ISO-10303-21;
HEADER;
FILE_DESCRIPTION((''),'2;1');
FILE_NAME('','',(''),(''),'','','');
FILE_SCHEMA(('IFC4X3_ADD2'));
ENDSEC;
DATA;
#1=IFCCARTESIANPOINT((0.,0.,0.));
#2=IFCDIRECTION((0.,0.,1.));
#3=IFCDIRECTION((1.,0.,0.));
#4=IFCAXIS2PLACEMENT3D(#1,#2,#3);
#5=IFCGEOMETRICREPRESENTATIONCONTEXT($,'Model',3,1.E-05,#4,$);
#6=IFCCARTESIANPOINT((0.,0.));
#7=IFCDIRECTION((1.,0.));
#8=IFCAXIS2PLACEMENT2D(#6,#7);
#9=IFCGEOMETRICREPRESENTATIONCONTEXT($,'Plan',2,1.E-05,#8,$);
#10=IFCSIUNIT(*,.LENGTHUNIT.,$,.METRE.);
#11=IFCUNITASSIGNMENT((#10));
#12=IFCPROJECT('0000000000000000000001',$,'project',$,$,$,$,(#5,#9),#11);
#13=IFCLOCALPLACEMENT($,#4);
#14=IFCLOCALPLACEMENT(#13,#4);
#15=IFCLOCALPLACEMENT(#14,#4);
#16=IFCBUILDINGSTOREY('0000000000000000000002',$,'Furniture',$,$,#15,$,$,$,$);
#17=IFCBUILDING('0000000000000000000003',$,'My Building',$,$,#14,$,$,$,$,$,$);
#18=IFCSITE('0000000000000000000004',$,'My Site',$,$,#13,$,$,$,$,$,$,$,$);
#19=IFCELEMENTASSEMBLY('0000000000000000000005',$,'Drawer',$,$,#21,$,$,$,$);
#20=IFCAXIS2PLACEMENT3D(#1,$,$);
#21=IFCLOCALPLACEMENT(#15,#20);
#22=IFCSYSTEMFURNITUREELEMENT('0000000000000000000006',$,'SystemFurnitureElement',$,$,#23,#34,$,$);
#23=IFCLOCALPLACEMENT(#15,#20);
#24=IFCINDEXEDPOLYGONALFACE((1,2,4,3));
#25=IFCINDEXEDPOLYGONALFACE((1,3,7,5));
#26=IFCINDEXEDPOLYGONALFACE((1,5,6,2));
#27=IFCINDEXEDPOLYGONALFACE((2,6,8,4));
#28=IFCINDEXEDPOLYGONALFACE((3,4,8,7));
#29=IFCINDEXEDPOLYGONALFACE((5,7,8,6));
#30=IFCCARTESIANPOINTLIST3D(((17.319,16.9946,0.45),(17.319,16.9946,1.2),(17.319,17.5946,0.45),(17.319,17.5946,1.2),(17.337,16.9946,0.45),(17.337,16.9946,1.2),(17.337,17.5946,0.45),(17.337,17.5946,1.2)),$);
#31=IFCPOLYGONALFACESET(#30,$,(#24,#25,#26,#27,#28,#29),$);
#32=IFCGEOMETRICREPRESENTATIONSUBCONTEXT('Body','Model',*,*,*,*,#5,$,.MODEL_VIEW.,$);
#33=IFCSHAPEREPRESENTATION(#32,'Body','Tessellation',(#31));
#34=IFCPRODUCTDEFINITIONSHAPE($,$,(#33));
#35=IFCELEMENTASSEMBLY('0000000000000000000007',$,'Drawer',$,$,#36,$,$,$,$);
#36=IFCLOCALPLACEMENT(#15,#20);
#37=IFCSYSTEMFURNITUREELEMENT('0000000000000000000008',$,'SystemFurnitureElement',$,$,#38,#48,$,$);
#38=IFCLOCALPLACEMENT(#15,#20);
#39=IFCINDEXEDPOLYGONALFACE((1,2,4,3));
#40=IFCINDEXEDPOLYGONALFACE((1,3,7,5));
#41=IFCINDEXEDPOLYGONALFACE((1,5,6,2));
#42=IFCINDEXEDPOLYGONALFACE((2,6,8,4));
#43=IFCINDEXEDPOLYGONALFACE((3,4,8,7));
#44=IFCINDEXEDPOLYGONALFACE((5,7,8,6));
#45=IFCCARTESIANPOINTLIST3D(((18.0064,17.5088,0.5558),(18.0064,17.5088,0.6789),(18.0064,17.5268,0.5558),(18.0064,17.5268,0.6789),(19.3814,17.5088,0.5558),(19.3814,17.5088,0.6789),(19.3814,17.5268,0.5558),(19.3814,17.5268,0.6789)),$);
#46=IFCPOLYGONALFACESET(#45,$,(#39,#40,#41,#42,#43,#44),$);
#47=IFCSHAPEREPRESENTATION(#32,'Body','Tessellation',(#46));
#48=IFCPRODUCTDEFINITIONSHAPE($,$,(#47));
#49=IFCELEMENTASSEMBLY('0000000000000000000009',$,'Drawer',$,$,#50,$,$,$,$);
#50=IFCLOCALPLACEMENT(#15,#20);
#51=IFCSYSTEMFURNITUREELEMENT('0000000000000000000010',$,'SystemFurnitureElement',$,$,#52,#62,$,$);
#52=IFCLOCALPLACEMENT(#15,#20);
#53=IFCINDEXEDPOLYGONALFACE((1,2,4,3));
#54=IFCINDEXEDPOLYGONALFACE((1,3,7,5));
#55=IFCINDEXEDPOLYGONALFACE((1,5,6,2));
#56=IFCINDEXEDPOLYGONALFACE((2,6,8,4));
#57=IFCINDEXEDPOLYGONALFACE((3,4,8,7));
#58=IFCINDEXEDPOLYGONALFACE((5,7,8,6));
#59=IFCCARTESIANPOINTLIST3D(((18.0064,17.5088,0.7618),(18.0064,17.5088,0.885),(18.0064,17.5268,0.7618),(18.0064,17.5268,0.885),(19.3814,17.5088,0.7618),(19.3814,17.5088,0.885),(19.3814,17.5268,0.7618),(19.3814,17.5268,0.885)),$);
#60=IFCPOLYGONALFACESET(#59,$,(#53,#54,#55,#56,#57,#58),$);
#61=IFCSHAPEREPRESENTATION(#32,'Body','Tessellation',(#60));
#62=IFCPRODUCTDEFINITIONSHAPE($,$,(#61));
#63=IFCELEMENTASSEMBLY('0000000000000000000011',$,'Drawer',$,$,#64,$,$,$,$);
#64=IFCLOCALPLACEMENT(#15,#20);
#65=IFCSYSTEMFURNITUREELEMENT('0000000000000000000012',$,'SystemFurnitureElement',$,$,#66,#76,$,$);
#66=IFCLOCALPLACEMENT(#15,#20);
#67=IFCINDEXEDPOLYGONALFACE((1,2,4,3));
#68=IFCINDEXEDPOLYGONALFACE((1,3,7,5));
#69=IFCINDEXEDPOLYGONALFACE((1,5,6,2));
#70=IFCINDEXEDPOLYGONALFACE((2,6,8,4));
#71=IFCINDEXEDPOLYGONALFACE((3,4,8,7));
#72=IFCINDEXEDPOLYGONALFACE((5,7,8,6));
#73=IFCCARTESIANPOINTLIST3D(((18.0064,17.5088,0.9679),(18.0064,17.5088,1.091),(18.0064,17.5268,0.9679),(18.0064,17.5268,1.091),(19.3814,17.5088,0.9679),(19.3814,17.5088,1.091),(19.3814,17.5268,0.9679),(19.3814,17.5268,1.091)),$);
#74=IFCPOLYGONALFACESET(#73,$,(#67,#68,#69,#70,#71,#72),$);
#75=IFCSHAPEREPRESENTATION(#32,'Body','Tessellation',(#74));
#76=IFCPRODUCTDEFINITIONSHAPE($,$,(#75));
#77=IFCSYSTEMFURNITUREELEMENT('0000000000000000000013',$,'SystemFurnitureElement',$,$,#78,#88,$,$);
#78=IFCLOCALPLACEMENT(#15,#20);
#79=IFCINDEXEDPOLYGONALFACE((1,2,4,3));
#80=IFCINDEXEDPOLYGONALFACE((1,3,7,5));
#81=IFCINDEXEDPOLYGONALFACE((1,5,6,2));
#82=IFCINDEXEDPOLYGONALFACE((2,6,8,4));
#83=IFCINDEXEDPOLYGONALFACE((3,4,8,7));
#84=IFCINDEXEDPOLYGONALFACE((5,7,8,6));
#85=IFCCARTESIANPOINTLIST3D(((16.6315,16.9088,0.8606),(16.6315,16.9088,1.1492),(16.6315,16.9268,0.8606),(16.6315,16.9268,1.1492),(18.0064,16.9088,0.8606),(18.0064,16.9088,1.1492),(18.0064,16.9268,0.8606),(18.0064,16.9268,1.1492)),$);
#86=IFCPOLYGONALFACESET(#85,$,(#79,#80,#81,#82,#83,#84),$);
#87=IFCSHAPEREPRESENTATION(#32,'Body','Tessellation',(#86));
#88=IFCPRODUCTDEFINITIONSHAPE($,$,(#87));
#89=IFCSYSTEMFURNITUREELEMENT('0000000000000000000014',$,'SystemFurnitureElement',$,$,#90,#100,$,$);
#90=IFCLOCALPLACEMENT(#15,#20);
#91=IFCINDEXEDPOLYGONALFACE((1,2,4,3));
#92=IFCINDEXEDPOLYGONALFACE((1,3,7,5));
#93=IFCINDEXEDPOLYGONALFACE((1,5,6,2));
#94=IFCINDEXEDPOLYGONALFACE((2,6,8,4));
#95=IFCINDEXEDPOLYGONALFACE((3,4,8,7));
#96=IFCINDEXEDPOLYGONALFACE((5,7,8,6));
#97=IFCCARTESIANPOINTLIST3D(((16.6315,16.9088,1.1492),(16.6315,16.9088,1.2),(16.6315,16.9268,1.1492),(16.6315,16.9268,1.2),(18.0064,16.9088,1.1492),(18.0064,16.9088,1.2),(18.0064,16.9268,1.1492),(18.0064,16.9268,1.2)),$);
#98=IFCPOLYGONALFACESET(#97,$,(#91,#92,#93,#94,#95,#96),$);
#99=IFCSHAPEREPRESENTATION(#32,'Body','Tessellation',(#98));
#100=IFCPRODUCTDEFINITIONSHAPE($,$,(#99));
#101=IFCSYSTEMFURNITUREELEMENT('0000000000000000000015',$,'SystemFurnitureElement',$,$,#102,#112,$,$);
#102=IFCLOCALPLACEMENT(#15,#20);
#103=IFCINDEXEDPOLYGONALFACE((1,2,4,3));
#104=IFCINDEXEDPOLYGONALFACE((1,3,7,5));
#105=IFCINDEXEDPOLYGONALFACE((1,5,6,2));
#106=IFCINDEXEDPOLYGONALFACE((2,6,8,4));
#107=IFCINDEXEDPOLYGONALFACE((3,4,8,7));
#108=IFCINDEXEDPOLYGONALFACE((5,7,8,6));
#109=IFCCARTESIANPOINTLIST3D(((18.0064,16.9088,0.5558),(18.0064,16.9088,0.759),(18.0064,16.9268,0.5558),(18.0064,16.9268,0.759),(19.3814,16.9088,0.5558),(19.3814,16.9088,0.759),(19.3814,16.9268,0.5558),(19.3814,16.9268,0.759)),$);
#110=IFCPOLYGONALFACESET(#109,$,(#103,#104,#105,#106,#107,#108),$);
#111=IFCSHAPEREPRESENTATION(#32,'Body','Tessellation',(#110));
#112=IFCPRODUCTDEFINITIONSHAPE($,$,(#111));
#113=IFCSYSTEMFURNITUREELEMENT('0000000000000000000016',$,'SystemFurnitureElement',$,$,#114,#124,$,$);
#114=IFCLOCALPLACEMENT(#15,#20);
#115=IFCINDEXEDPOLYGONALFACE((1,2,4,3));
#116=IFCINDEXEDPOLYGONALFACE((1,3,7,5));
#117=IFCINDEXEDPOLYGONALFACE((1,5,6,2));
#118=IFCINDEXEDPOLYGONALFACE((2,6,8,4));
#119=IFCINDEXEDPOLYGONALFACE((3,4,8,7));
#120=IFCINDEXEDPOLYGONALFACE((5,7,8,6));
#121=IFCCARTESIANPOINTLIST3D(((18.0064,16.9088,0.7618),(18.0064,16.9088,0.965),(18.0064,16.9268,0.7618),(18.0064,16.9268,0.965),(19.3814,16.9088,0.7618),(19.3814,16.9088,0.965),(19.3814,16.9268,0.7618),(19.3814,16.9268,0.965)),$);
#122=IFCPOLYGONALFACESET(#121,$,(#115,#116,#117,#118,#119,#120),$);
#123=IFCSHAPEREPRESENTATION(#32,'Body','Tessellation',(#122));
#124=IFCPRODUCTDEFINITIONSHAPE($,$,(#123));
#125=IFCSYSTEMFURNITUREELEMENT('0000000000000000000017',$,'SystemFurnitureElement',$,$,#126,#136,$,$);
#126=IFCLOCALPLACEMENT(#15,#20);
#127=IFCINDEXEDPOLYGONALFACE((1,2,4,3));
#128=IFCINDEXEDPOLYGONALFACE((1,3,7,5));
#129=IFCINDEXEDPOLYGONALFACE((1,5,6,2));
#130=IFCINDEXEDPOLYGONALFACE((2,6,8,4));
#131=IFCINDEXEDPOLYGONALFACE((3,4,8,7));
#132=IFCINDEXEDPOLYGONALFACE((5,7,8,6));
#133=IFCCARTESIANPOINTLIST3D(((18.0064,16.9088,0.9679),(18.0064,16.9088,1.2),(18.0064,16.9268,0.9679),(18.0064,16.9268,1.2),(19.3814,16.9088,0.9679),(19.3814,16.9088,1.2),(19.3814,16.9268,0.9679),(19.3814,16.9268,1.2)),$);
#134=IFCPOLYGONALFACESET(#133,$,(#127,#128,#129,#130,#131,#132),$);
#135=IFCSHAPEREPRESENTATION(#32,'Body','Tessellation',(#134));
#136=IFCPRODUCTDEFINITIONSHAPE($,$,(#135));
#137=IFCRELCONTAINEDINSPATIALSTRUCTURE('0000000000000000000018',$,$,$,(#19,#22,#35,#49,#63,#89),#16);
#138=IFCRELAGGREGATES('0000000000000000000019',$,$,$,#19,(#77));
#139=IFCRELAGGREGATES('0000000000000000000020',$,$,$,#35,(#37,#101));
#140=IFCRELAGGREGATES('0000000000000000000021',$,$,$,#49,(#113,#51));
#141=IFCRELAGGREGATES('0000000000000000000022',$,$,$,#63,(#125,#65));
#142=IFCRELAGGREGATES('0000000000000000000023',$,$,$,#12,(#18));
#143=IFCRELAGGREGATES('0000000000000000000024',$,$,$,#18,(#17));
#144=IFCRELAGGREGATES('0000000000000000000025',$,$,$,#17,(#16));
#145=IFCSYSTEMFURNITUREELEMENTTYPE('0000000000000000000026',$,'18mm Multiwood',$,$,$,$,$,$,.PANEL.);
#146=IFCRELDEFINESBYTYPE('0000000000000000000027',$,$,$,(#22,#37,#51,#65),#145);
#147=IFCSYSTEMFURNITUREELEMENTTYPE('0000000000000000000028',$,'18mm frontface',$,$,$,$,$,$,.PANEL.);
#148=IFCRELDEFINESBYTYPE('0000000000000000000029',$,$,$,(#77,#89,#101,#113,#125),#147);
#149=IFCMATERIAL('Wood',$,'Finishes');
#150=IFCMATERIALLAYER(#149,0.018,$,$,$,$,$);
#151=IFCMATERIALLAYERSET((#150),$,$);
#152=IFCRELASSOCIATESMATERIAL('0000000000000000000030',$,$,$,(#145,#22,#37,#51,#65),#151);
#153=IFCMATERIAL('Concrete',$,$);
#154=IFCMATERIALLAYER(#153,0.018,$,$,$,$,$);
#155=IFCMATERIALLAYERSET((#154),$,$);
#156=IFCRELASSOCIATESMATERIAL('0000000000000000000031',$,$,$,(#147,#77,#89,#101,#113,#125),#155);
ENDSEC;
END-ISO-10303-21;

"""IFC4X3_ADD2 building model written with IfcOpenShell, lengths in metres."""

from ifc_helpers import new_model, si_unit, frame, origin_with_axes, origin_2d_with_axis, place, context, subcontext, project, spatial, line, indexed_curve, outline, extrude, material, layer, layer_set, layer_usage, type_object, element, aggregate, save


model = new_model("IFC4X3_ADD2")

# Units and contexts
model_context = context("Model", 3, precision=1e-05, world=origin_with_axes())
plan_context = context("Plan", 2, precision=1e-05, world=origin_2d_with_axis())
body_context = subcontext(model_context, "Body", "Model", "MODEL_VIEW")
ifc_project = project(units=[si_unit("LENGTHUNIT", "METRE")], contexts=[model_context, plan_context])

# Site, building, storey
site_placement = place(None, origin_with_axes())
site = spatial("IfcSite", under=ifc_project, at=site_placement, Name="My Site")
building_placement = place(site_placement, origin_with_axes())
building = spatial("IfcBuilding", under=site, at=building_placement, Name="My Building")
storey_placement = place(building_placement, origin_with_axes())
storey = spatial("IfcBuildingStorey", under=building, at=storey_placement, Name="Furniture")

# Shared definitions
ifc_material_1 = material(Name="Wood", Category="Finishes")
ifc_layer_1 = layer(ifc_material_1, 0.018)
ifc_layer_set_1 = layer_set([ifc_layer_1])
system_furniture_element_type_1 = type_object("IfcSystemFurnitureElementType", Name="18mm Multiwood", PredefinedType="PANEL", material=ifc_layer_set_1)

# Element assembly
assembly_1_placement = place(storey_placement, frame((16.6315, 16.9088, 0.8606), z_axis=(0.0, 0.0, 1.0), x_axis=(-1.0, 0.0, 0.0)))
assembly_1 = element("IfcElementAssembly", 1, at=assembly_1_placement, inside=storey, Name="Drawer")

# System furniture element
ifc_layer_usage_1 = layer_usage(ifc_layer_set_1, "AXIS2", "POSITIVE", 0.0)
system_furniture_element_1_placement = place(storey_placement, frame((17.337, 16.9946, 0.45), z_axis=(0.0, 0.0, 1.0), x_axis=(0.000001, 1.0, 0.0)))
element("IfcSystemFurnitureElement", 2, at=system_furniture_element_1_placement, inside=storey, type_object=system_furniture_element_type_1, material=ifc_layer_usage_1, Name="SystemFurnitureElement", context=body_context, shape_type="SweptSolid", body=[
    extrude(outline(indexed_curve([(0.0, 0.0), (0.0, 0.018), (0.6, 0.018), (0.6, 0.0)], segments=[line(1, 2, 3, 4, 1)])), origin_with_axes(), (0.0, 0.0, 1.0), 0.75),
])

# Element assemblies, system furniture elements
assembly_2_placement = place(storey_placement, frame((18.0064, 16.9088, 0.5558), z_axis=(0.0, 0.0, 1.0), x_axis=(-1.0, 0.0, 0.0)))
assembly_2 = element("IfcElementAssembly", 3, at=assembly_2_placement, inside=storey, Name="Drawer")
ifc_layer_usage_2 = layer_usage(ifc_layer_set_1, "AXIS2", "POSITIVE", 0.0)
system_furniture_element_2_placement = place(assembly_2_placement, frame((-1.375, -0.618, 0.0), z_axis=(0.0, 0.0, 1.0), x_axis=(1.0, 0.0, 0.0)))
system_furniture_element_2 = element("IfcSystemFurnitureElement", 4, at=system_furniture_element_2_placement, type_object=system_furniture_element_type_1, material=ifc_layer_usage_2, Name="SystemFurnitureElement", context=body_context, shape_type="SweptSolid", body=[
    extrude(outline(indexed_curve([(0.0, 0.0), (0.0, 0.018), (1.375, 0.018), (1.375, 0.0)], segments=[line(1, 2, 3, 4, 1)])), origin_with_axes(), (0.0, 0.0, 1.0), 0.1231),
])
assembly_3_placement = place(storey_placement, frame((18.0064, 16.9088, 0.7618), z_axis=(0.0, 0.0, 1.0), x_axis=(-1.0, 0.0, 0.0)))
assembly_3 = element("IfcElementAssembly", 5, at=assembly_3_placement, inside=storey, Name="Drawer")
ifc_layer_usage_3 = layer_usage(ifc_layer_set_1, "AXIS2", "POSITIVE", 0.0)
system_furniture_element_3_placement = place(assembly_3_placement, frame((-1.375, -0.618, 0.0), z_axis=(0.0, 0.0, 1.0), x_axis=(1.0, 0.0, 0.0)))
system_furniture_element_3 = element("IfcSystemFurnitureElement", 6, at=system_furniture_element_3_placement, type_object=system_furniture_element_type_1, material=ifc_layer_usage_3, Name="SystemFurnitureElement", context=body_context, shape_type="SweptSolid", body=[
    extrude(outline(indexed_curve([(0.0, 0.0), (0.0, 0.018), (1.375, 0.018), (1.375, 0.0)], segments=[line(1, 2, 3, 4, 1)])), origin_with_axes(), (0.0, 0.0, 1.0), 0.1231),
])
assembly_4_placement = place(storey_placement, frame((18.0064, 16.9088, 0.9679), z_axis=(0.0, 0.0, 1.0), x_axis=(-1.0, 0.0, 0.0)))
assembly_4 = element("IfcElementAssembly", 7, at=assembly_4_placement, inside=storey, Name="Drawer")
ifc_layer_usage_4 = layer_usage(ifc_layer_set_1, "AXIS2", "POSITIVE", 0.0)
system_furniture_element_4_placement = place(assembly_4_placement, frame((-1.375, -0.618, 0.0), z_axis=(0.0, 0.0, 1.0), x_axis=(1.0, 0.0, 0.0)))
system_furniture_element_4 = element("IfcSystemFurnitureElement", 8, at=system_furniture_element_4_placement, type_object=system_furniture_element_type_1, material=ifc_layer_usage_4, Name="SystemFurnitureElement", context=body_context, shape_type="SweptSolid", body=[
    extrude(outline(indexed_curve([(0.0, 0.0), (0.0, 0.018), (1.375, 0.018), (1.375, 0.0)], segments=[line(1, 2, 3, 4, 1)])), origin_with_axes(), (0.0, 0.0, 1.0), 0.1231),
])

# System furniture elements
ifc_material_2 = material(Name="Concrete")
ifc_layer_2 = layer(ifc_material_2, 0.018)
ifc_layer_set_2 = layer_set([ifc_layer_2])
ifc_layer_usage_5 = layer_usage(ifc_layer_set_2, "AXIS2", "POSITIVE", 0.0)
system_furniture_element_type_2 = type_object("IfcSystemFurnitureElementType", Name="18mm frontface", PredefinedType="PANEL", material=ifc_layer_set_2)
system_furniture_element_5_placement = place(assembly_1_placement, frame((-1.375, -0.018, 0.0), z_axis=(0.0, 0.0, 1.0), x_axis=(1.0, 0.0, 0.0)))
system_furniture_element_5 = element("IfcSystemFurnitureElement", 9, at=system_furniture_element_5_placement, type_object=system_furniture_element_type_2, material=ifc_layer_usage_5, Name="SystemFurnitureElement", context=body_context, shape_type="SweptSolid", body=[
    extrude(outline(indexed_curve([(0.0, 0.0), (0.0, 0.018), (1.375, 0.018), (1.375, 0.0)], segments=[line(1, 2, 3, 4, 1)])), origin_with_axes(), (0.0, 0.0, 1.0), 0.2886),
])
aggregate(assembly_1, [system_furniture_element_5])
ifc_layer_usage_6 = layer_usage(ifc_layer_set_2, "AXIS2", "POSITIVE", 0.0)
system_furniture_element_6_placement = place(storey_placement, frame((18.0064, 16.9268, 1.1492), z_axis=(0.0, 0.0, 1.0), x_axis=(-1.0, 0.000001, 0.0)))
element("IfcSystemFurnitureElement", 10, at=system_furniture_element_6_placement, inside=storey, type_object=system_furniture_element_type_2, material=ifc_layer_usage_6, Name="SystemFurnitureElement", context=body_context, shape_type="SweptSolid", body=[
    extrude(outline(indexed_curve([(0.0, 0.0), (0.0, 0.018), (1.375, 0.018), (1.375, 0.0)], segments=[line(1, 2, 3, 4, 1)])), origin_with_axes(), (0.0, 0.0, 1.0), 0.0508),
])
ifc_layer_usage_7 = layer_usage(ifc_layer_set_2, "AXIS2", "POSITIVE", 0.0)
system_furniture_element_7_placement = place(assembly_2_placement, frame((-1.375, -0.018, 0.0), z_axis=(0.0, 0.0, 1.0), x_axis=(1.0, 0.0, 0.0)))
system_furniture_element_7 = element("IfcSystemFurnitureElement", 11, at=system_furniture_element_7_placement, type_object=system_furniture_element_type_2, material=ifc_layer_usage_7, Name="SystemFurnitureElement", context=body_context, shape_type="SweptSolid", body=[
    extrude(outline(indexed_curve([(0.0, 0.0), (0.0, 0.018), (1.375, 0.018), (1.375, 0.0)], segments=[line(1, 2, 3, 4, 1)])), origin_with_axes(), (0.0, 0.0, 1.0), 0.2032),
])
aggregate(assembly_2, [system_furniture_element_2, system_furniture_element_7])
ifc_layer_usage_8 = layer_usage(ifc_layer_set_2, "AXIS2", "POSITIVE", 0.0)
system_furniture_element_8_placement = place(assembly_3_placement, frame((-1.375, -0.018, 0.0), z_axis=(0.0, 0.0, 1.0), x_axis=(1.0, 0.0, 0.0)))
system_furniture_element_8 = element("IfcSystemFurnitureElement", 12, at=system_furniture_element_8_placement, type_object=system_furniture_element_type_2, material=ifc_layer_usage_8, Name="SystemFurnitureElement", context=body_context, shape_type="SweptSolid", body=[
    extrude(outline(indexed_curve([(0.0, 0.0), (0.0, 0.018), (1.375, 0.018), (1.375, 0.0)], segments=[line(1, 2, 3, 4, 1)])), origin_with_axes(), (0.0, 0.0, 1.0), 0.2032),
])
aggregate(assembly_3, [system_furniture_element_8, system_furniture_element_3])
ifc_layer_usage_9 = layer_usage(ifc_layer_set_2, "AXIS2", "POSITIVE", 0.0)
system_furniture_element_9_placement = place(assembly_4_placement, frame((-1.375, -0.018, 0.0), z_axis=(0.0, 0.0, 1.0), x_axis=(1.0, 0.0, 0.0)))
system_furniture_element_9 = element("IfcSystemFurnitureElement", 13, at=system_furniture_element_9_placement, type_object=system_furniture_element_type_2, material=ifc_layer_usage_9, Name="SystemFurnitureElement", context=body_context, shape_type="SweptSolid", body=[
    extrude(outline(indexed_curve([(0.0, 0.0), (0.0, 0.018), (1.375, 0.018), (1.375, 0.0)], segments=[line(1, 2, 3, 4, 1)])), origin_with_axes(), (0.0, 0.0, 1.0), 0.2321),
])
aggregate(assembly_4, [system_furniture_element_9, system_furniture_element_4])

save(model, "model.ifc")
